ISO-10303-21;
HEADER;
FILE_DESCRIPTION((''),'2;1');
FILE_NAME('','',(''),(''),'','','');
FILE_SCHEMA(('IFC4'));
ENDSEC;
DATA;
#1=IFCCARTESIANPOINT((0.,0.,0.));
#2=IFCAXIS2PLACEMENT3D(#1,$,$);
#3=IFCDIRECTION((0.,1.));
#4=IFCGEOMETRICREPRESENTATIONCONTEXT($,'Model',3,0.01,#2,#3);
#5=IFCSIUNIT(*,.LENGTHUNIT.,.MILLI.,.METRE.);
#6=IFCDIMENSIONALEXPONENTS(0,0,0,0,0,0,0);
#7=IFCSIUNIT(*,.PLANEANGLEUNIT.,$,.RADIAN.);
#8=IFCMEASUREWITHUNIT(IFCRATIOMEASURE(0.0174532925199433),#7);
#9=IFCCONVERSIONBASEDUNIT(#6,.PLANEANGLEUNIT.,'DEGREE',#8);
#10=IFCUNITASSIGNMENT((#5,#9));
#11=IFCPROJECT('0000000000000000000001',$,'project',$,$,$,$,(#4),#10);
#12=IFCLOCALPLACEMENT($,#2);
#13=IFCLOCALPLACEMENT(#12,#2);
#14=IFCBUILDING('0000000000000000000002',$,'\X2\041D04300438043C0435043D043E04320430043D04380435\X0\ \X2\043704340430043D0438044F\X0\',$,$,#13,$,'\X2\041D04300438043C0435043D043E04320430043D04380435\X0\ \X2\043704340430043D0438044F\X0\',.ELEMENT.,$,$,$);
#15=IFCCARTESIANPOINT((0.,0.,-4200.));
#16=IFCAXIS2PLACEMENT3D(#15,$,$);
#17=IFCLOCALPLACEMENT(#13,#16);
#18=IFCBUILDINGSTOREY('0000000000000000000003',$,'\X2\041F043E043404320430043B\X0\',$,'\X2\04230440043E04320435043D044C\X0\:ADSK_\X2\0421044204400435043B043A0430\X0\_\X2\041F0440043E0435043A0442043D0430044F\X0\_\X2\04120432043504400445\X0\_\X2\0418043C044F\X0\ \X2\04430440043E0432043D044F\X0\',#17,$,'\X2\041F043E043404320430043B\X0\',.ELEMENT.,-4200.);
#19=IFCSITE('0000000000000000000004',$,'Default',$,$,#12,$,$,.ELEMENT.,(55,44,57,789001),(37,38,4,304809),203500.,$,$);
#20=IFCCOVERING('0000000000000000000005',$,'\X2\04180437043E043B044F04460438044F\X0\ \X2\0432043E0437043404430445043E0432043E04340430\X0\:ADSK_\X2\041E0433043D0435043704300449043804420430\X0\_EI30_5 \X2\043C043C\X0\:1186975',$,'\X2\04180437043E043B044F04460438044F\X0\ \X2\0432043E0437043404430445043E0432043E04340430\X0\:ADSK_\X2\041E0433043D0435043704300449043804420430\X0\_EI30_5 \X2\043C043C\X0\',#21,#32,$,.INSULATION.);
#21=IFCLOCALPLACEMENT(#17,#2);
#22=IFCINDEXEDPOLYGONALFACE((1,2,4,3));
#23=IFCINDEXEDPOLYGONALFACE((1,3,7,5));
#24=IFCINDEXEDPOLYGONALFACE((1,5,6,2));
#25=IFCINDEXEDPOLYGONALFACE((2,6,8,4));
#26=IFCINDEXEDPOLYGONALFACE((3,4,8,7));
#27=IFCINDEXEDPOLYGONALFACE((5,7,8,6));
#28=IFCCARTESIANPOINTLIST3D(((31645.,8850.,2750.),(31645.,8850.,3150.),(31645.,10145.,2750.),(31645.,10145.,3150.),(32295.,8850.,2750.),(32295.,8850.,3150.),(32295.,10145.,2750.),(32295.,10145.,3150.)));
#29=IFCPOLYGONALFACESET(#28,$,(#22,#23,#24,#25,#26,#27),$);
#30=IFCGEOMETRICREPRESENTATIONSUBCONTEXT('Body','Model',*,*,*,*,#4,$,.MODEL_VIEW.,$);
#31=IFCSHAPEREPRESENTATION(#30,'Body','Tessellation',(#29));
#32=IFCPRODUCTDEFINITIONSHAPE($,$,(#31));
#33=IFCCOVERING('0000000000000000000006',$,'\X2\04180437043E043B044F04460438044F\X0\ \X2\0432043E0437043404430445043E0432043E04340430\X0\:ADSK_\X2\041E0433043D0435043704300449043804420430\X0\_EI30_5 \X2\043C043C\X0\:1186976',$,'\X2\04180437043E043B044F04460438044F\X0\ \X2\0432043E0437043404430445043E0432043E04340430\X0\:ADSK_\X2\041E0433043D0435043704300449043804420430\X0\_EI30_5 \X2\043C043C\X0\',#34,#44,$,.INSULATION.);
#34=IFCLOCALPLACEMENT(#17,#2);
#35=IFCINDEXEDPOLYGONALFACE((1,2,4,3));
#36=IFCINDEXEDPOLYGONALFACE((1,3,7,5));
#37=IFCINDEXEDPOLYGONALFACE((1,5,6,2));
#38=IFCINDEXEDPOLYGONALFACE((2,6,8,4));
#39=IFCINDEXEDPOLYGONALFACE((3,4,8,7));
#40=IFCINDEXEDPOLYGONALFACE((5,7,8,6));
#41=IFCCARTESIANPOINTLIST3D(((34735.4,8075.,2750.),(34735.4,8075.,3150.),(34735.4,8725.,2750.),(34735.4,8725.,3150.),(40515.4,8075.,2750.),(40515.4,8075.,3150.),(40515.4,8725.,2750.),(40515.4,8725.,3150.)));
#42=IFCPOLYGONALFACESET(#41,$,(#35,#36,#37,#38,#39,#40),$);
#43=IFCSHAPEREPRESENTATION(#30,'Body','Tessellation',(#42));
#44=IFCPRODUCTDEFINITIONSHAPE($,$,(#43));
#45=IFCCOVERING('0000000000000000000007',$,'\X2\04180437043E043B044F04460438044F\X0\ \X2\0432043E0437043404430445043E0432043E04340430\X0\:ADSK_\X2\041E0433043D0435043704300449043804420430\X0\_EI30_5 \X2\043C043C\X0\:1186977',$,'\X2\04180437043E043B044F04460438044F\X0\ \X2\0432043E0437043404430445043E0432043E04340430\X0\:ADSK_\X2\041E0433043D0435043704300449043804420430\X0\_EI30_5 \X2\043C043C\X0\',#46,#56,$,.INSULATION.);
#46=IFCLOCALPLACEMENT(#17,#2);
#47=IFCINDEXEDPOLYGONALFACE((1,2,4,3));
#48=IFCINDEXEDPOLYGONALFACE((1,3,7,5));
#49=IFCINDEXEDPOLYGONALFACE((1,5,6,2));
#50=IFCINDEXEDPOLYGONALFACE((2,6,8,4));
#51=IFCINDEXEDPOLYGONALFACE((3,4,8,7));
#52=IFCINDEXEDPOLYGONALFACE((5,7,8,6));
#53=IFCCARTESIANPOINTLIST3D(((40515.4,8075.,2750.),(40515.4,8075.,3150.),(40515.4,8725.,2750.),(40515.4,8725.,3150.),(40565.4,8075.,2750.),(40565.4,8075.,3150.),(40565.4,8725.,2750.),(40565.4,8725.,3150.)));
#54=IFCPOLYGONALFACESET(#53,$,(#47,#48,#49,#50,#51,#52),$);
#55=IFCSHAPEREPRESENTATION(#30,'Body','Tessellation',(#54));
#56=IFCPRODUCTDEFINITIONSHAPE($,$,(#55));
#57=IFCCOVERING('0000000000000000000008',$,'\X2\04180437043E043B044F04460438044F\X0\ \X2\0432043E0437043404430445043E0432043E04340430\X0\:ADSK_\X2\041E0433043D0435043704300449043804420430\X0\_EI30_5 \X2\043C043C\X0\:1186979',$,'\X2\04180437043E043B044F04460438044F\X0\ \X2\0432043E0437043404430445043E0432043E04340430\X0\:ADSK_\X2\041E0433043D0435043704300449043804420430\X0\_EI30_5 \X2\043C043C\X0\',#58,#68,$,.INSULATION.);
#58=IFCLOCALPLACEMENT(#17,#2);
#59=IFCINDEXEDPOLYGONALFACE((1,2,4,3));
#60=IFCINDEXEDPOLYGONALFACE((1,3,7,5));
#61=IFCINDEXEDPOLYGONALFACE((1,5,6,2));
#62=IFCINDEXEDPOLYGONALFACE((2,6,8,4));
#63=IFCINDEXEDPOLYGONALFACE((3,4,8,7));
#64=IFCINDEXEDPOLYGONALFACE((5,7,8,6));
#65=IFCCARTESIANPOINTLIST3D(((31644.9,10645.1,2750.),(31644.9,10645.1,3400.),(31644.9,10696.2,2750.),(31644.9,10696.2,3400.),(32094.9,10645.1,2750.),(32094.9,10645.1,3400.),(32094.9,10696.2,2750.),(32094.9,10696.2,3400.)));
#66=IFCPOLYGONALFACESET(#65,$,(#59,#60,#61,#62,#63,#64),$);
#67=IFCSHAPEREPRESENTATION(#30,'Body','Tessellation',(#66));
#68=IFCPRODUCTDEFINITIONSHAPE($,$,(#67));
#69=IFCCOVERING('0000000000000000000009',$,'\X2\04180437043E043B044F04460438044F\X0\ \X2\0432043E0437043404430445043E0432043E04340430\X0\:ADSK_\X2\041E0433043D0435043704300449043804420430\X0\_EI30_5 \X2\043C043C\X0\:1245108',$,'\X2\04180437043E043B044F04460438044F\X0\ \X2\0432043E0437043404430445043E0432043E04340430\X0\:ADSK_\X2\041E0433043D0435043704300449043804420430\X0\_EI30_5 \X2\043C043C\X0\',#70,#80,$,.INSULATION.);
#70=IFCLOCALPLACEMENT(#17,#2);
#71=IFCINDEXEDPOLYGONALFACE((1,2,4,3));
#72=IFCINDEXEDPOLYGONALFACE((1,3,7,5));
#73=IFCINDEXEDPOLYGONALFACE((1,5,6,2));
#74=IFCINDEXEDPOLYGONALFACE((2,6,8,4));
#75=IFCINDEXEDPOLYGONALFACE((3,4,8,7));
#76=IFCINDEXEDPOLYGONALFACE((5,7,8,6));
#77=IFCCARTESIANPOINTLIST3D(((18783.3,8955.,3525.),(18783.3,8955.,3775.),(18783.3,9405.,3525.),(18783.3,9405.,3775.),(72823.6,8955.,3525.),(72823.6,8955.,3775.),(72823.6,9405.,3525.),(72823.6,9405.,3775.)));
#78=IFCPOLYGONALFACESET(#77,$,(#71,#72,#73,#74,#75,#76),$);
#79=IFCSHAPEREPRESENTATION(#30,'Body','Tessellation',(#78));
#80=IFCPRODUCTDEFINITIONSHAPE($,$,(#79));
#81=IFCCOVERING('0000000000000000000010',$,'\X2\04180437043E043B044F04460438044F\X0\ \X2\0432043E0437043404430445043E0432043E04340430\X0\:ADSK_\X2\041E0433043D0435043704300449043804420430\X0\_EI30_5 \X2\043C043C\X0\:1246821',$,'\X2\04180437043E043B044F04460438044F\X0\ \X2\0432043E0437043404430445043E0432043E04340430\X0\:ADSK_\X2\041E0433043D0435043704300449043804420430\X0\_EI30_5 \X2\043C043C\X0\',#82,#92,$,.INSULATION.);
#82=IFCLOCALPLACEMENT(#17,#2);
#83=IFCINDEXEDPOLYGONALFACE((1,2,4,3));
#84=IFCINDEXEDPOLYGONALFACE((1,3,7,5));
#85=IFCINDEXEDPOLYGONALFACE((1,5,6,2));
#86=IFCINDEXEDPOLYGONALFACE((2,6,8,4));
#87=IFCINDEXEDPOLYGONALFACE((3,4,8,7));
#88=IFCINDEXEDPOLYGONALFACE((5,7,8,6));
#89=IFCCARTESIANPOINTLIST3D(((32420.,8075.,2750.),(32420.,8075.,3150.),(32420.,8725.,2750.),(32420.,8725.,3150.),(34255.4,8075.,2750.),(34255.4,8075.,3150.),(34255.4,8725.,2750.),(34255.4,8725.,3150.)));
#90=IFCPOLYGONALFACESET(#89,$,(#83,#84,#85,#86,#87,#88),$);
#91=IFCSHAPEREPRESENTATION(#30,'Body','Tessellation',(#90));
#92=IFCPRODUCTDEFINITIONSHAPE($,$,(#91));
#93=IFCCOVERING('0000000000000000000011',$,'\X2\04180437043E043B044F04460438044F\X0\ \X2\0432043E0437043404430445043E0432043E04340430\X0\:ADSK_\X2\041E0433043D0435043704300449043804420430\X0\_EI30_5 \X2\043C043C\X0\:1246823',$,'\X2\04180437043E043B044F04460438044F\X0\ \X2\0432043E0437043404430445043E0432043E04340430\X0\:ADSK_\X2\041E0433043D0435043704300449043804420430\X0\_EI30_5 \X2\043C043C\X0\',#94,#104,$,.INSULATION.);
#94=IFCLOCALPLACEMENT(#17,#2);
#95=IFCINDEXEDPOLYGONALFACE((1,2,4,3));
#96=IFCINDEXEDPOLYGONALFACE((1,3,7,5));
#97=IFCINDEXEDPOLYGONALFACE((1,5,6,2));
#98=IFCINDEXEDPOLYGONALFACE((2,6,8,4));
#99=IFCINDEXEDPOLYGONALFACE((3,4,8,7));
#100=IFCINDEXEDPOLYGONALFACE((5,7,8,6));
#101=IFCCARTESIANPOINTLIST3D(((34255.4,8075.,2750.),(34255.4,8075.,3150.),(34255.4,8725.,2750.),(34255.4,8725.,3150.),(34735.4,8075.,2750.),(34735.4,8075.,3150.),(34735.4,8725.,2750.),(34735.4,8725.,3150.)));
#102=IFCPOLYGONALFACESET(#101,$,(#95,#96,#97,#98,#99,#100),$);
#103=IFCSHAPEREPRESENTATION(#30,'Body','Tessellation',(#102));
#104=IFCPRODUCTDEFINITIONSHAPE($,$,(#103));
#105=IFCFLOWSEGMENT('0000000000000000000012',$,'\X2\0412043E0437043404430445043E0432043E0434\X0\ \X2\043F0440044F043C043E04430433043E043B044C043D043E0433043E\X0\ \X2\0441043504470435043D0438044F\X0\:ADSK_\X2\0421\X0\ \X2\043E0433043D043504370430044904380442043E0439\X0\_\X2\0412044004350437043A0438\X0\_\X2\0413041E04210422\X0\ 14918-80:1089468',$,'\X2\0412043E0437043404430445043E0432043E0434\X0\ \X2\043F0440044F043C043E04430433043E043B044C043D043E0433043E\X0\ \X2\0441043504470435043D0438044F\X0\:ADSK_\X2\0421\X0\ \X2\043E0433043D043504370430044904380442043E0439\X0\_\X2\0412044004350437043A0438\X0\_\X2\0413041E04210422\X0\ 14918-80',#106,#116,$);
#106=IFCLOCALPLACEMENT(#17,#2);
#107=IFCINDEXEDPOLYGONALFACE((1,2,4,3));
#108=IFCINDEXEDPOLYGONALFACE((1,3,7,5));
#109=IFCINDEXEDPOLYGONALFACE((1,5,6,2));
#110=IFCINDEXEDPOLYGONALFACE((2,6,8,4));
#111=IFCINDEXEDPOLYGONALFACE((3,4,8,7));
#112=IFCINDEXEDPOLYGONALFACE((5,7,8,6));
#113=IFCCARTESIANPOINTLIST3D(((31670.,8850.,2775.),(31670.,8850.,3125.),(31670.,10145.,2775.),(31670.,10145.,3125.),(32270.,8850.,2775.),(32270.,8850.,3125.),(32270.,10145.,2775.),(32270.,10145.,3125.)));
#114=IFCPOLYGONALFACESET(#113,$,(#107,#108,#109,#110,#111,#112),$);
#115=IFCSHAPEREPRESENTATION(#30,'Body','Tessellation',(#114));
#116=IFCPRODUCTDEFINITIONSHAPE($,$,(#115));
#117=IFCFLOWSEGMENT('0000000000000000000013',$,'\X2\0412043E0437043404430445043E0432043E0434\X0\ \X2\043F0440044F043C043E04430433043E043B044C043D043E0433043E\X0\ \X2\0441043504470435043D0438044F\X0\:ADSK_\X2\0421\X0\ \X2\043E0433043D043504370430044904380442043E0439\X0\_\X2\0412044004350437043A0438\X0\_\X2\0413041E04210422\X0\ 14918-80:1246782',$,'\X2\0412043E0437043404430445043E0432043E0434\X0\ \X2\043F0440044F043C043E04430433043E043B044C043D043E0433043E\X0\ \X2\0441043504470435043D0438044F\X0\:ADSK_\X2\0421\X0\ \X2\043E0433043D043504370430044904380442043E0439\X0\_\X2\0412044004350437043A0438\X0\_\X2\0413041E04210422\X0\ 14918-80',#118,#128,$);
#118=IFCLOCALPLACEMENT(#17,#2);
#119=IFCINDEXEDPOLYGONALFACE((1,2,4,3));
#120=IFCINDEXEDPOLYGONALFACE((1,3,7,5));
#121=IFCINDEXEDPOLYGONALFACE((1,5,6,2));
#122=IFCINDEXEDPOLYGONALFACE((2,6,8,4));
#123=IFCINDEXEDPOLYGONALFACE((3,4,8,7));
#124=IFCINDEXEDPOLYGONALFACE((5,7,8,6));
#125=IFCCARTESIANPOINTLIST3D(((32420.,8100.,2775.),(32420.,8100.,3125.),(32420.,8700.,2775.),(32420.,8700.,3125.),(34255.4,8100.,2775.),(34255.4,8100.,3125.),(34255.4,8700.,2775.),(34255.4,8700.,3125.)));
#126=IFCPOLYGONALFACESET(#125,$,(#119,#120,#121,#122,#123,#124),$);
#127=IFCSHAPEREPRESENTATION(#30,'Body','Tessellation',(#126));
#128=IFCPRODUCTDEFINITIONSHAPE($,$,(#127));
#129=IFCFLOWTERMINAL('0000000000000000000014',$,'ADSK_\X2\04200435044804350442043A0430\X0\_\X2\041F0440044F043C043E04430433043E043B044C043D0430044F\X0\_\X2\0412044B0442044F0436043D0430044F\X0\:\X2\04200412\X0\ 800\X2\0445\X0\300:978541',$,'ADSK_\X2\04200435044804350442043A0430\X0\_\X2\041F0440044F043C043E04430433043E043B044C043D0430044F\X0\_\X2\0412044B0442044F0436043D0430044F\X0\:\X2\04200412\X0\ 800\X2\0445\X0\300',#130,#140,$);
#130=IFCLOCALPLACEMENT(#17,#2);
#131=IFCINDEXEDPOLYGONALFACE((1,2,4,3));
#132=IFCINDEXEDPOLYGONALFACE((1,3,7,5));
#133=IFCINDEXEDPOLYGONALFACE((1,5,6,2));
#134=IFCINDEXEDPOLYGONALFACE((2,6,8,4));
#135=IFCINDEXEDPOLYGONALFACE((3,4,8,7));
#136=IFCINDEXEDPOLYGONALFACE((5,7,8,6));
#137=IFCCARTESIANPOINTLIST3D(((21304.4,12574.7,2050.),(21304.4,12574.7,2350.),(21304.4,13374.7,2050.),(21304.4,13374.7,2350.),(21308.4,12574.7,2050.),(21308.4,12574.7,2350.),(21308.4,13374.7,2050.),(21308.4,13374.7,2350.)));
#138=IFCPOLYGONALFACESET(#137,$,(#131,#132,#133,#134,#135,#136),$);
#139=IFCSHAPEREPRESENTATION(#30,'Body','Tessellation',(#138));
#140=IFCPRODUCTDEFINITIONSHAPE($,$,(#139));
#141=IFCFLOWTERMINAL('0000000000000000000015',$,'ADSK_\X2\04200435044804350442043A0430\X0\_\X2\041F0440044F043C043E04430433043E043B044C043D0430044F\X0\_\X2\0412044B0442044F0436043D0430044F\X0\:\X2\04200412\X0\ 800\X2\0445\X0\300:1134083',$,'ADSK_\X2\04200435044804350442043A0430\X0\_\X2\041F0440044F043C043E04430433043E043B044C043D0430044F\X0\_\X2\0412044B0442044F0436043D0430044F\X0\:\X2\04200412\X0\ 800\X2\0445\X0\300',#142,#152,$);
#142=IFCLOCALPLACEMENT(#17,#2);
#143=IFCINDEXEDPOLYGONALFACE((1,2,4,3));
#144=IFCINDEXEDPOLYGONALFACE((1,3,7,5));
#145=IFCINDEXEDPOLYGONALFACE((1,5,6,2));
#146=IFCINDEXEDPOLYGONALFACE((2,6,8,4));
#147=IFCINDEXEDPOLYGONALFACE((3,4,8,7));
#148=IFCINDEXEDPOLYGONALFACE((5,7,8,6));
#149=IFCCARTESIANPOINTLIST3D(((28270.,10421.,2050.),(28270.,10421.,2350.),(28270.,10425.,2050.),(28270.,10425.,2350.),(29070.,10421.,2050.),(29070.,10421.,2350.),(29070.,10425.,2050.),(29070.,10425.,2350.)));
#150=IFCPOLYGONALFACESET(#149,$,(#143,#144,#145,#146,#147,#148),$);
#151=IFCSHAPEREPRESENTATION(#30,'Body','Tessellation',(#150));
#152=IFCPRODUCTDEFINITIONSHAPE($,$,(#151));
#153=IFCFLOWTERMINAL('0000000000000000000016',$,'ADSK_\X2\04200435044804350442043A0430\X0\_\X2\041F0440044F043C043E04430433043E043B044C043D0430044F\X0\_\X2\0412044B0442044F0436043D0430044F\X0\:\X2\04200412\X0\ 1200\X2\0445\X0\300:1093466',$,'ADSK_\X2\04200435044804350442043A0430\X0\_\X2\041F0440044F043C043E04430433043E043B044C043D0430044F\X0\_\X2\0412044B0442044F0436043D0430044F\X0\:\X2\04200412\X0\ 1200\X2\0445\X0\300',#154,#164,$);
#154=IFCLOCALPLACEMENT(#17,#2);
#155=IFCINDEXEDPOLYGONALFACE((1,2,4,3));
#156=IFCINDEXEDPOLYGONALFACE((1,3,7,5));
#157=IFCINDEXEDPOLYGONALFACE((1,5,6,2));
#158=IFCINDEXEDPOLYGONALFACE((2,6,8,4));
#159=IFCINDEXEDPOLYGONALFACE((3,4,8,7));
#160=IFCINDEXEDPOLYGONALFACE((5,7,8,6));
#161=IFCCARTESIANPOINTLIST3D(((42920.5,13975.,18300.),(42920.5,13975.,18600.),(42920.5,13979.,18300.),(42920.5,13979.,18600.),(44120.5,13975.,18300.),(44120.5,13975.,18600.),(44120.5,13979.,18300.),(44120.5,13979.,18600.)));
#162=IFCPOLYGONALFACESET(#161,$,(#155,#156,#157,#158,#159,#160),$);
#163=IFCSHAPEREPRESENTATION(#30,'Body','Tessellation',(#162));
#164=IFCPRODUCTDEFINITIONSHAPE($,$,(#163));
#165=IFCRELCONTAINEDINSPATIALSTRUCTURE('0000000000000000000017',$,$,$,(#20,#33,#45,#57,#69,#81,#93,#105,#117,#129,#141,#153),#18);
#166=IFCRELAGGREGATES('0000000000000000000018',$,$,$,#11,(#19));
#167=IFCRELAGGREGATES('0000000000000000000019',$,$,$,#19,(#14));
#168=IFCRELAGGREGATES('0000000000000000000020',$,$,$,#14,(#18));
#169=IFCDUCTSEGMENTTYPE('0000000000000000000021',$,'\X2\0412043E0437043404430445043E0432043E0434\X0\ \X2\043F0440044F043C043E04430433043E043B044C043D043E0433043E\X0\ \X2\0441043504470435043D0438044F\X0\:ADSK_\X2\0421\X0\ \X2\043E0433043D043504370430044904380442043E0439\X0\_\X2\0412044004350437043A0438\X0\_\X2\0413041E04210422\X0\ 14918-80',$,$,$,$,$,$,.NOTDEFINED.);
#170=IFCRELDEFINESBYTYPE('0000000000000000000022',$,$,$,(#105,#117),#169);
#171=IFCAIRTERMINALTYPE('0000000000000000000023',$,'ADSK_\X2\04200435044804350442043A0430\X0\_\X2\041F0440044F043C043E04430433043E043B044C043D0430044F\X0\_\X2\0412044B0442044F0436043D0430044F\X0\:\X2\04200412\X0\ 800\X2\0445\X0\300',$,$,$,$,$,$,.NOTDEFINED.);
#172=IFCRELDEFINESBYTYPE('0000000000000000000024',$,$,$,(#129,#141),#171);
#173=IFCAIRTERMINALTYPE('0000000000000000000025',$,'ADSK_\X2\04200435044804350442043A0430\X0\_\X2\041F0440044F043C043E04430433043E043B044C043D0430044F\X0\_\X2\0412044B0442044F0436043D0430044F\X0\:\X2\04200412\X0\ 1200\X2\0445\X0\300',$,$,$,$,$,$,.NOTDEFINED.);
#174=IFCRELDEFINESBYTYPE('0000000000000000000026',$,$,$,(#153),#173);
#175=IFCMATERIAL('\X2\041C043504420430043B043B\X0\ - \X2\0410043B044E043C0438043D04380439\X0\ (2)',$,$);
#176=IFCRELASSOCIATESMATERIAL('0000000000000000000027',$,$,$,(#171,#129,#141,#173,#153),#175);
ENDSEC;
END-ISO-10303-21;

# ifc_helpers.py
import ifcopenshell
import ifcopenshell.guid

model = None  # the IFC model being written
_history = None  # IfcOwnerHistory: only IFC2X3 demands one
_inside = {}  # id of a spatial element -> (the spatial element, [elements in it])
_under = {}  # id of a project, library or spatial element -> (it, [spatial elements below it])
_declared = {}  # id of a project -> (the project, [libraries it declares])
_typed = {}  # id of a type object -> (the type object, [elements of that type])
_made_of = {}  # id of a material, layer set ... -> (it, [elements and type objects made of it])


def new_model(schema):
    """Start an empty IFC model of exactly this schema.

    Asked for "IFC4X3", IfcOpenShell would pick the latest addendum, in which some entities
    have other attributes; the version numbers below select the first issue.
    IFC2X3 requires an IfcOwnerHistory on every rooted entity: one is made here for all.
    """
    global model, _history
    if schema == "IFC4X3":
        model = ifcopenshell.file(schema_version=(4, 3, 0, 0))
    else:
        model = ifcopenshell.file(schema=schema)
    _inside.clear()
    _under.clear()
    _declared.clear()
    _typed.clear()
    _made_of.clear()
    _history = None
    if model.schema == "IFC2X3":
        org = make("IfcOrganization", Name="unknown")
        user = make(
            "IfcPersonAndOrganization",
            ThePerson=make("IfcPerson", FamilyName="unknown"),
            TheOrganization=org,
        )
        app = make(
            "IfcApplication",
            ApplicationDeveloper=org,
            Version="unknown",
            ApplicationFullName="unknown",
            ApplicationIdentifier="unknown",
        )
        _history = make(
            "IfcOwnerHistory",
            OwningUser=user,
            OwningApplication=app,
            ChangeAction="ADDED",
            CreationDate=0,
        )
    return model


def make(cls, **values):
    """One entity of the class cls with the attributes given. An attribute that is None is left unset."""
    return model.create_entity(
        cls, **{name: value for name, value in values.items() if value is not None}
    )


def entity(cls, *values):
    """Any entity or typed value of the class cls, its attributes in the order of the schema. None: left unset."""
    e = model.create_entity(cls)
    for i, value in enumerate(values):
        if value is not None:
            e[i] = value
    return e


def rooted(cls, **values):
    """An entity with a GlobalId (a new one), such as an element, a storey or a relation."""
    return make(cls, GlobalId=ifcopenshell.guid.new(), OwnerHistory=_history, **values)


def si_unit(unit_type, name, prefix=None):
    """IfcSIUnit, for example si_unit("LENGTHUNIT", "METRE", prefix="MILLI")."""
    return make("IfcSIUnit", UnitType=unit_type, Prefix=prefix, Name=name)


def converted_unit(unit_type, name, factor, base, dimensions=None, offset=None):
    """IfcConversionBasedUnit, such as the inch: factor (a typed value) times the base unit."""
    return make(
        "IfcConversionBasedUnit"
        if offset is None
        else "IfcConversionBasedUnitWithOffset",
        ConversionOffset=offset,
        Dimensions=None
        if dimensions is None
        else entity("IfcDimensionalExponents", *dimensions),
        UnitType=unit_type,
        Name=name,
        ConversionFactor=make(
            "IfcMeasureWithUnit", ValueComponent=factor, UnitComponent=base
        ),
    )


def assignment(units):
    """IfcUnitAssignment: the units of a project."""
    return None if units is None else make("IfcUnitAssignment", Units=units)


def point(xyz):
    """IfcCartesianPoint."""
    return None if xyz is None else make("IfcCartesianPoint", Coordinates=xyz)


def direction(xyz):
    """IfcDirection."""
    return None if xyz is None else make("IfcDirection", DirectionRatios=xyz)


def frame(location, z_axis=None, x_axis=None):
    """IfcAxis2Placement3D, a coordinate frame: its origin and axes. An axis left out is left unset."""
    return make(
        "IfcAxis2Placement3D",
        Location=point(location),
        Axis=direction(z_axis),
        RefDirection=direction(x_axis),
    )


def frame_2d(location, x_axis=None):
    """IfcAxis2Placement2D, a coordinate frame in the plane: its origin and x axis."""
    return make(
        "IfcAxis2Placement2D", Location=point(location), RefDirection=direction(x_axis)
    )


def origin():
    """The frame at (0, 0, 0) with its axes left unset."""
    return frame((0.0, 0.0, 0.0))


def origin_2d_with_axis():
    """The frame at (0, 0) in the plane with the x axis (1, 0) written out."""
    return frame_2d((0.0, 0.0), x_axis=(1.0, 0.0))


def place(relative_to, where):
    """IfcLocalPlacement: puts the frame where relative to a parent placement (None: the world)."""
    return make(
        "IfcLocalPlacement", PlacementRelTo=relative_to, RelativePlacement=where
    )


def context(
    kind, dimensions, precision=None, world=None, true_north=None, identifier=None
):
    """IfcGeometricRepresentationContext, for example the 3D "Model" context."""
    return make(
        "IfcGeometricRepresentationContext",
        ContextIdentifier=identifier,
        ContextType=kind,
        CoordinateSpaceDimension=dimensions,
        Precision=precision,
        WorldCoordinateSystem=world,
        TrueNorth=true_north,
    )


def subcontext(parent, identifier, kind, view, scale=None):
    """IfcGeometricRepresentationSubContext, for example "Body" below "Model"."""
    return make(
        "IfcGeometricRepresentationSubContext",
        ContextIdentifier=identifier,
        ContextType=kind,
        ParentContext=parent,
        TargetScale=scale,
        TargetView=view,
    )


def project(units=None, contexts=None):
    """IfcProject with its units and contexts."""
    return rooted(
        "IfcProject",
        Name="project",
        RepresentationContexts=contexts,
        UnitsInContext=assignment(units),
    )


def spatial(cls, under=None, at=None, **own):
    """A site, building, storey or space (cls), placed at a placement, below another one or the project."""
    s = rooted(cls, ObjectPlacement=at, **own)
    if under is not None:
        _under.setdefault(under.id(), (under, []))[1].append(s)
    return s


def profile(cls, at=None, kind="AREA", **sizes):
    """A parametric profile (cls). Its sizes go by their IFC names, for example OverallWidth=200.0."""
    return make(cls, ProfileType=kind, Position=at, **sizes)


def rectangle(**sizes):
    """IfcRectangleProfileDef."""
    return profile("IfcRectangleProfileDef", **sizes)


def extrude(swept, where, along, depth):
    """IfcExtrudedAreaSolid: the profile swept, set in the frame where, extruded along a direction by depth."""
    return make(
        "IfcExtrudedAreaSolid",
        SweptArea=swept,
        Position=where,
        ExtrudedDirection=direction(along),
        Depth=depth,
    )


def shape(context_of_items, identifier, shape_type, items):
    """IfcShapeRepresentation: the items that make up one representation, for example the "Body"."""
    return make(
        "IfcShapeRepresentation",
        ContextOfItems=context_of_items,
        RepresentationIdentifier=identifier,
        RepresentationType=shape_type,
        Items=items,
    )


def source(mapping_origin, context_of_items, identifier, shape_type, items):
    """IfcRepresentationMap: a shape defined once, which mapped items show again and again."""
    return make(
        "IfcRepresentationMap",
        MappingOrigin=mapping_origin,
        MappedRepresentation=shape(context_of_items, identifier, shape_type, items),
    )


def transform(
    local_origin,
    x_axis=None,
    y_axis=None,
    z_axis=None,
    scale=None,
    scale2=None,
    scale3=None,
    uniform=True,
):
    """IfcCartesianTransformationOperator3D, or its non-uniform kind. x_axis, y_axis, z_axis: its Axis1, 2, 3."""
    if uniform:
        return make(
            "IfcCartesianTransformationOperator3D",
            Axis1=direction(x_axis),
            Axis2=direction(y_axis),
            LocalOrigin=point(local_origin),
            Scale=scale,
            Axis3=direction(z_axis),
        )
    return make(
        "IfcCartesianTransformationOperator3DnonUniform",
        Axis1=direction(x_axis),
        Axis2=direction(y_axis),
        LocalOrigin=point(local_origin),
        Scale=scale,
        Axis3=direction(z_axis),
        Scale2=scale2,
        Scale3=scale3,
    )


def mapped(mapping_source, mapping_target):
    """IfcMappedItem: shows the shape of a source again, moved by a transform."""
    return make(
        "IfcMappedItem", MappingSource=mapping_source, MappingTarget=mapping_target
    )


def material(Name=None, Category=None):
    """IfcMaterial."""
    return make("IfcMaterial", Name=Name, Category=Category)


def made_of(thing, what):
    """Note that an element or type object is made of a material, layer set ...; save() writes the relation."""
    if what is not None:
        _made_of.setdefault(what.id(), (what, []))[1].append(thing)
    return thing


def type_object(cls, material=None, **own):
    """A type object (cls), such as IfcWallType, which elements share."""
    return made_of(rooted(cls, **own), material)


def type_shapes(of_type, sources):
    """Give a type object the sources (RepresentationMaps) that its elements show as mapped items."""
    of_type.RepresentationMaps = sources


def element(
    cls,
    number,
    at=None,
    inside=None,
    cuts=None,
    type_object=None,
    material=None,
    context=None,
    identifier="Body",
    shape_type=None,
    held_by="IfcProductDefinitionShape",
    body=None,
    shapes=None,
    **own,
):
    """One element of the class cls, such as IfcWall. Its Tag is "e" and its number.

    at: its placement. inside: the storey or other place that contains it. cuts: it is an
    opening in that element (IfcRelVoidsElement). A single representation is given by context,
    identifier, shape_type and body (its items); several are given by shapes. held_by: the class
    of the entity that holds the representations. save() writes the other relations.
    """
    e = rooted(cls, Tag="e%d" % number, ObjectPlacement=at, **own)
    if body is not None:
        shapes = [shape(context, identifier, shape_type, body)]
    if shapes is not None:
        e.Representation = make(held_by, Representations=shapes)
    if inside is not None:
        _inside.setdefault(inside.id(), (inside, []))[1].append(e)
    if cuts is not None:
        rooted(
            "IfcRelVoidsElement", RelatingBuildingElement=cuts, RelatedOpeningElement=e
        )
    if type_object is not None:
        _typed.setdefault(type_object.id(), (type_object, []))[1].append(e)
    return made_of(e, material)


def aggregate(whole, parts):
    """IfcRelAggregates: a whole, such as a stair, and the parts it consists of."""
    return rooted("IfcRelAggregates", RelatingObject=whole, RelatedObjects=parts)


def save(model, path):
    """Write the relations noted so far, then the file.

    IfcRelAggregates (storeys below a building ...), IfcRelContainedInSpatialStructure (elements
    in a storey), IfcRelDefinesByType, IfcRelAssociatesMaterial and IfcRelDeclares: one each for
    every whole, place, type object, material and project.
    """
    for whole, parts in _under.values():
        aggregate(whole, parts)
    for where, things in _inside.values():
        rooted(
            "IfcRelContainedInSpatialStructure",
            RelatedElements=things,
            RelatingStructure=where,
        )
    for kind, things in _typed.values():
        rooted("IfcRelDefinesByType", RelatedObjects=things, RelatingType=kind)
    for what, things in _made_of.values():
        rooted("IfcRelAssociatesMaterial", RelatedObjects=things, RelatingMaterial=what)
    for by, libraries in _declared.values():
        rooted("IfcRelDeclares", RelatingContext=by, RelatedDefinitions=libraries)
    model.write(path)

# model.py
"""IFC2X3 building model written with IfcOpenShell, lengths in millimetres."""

from ifc_helpers import new_model, entity, si_unit, converted_unit, direction, frame, origin, origin_2d_with_axis, place, context, subcontext, project, spatial, rectangle, extrude, source, transform, mapped, material, type_object, type_shapes, element, save


model = new_model("IFC2X3")

# Units and contexts
model_context = context("Model", 3, precision=0.01, world=origin(), true_north=direction((0.0, 1.0)))
body_context = subcontext(model_context, "Body", "Model", "MODEL_VIEW")
ifc_project = project(units=[si_unit("LENGTHUNIT", "METRE", prefix="MILLI"), converted_unit("PLANEANGLEUNIT", "DEGREE", entity("IfcRatioMeasure", 0.0174532925199433), si_unit("PLANEANGLEUNIT", "RADIAN"), dimensions=[0, 0, 0, 0, 0, 0, 0])], contexts=[model_context])

# Site, building, storey
site_placement = place(None, origin())
site = spatial("IfcSite", under=ifc_project, at=site_placement, Name="Default", CompositionType="ELEMENT", RefLatitude=(55, 44, 57, 789001), RefLongitude=(37, 38, 4, 304809), RefElevation=203500.0)
building_placement = place(site_placement, origin())
building = spatial("IfcBuilding", under=site, at=building_placement, Name="Наименование здания", LongName="Наименование здания", CompositionType="ELEMENT")
storey_placement = place(building_placement, frame((0.0, 0.0, -4200.0)))
storey = spatial("IfcBuildingStorey", under=building, at=storey_placement, Name="Подвал", ObjectType="Уровень:ADSK_Стрелка_Проектная_Вверх_Имя уровня", LongName="Подвал", CompositionType="ELEMENT", Elevation=-4200.0)

# Coverings
covering_1_placement = place(storey_placement, frame((31645.0, 8850.0, 2750.0)))
element("IfcCovering", 1, at=covering_1_placement, inside=storey, Name="Изоляция воздуховода:ADSK_Огнезащита_EI30_5 мм:1186975", ObjectType="Изоляция воздуховода:ADSK_Огнезащита_EI30_5 мм", PredefinedType="INSULATION", context=body_context, shape_type="SweptSolid", body=[
    extrude(rectangle(XDim=1295.0, YDim=650.0, at=origin_2d_with_axis()), frame((325.0, 647.5, 0.0), z_axis=(0.0, 0.0, 1.0), x_axis=(0.0, -1.0, 0.0)), (0.0, 0.0, 1.0), 400.0),
])
covering_2_placement = place(storey_placement, frame((34735.4, 8075.0, 2750.0)))
element("IfcCovering", 2, at=covering_2_placement, inside=storey, Name="Изоляция воздуховода:ADSK_Огнезащита_EI30_5 мм:1186976", ObjectType="Изоляция воздуховода:ADSK_Огнезащита_EI30_5 мм", PredefinedType="INSULATION", context=body_context, shape_type="SweptSolid", body=[
    extrude(rectangle(XDim=5780.0, YDim=650.0, at=origin_2d_with_axis()), frame((2890.0, 325.0, 0.0), z_axis=(0.0, 0.0, 1.0), x_axis=(-1.0, 0.0, 0.0)), (0.0, 0.0, 1.0), 400.0),
])
covering_3_placement = place(storey_placement, frame((40515.4, 8075.0, 2750.0)))
element("IfcCovering", 3, at=covering_3_placement, inside=storey, Name="Изоляция воздуховода:ADSK_Огнезащита_EI30_5 мм:1186977", ObjectType="Изоляция воздуховода:ADSK_Огнезащита_EI30_5 мм", PredefinedType="INSULATION", context=body_context, shape_type="SweptSolid", body=[
    extrude(rectangle(XDim=50.0, YDim=650.0, at=origin_2d_with_axis()), frame((25.0, 325.0, 0.0), z_axis=(0.0, 0.0, 1.0), x_axis=(-1.0, 0.0, 0.0)), (0.0, 0.0, 1.0), 400.0),
])
covering_4_placement = place(storey_placement, frame((31644.9, 10645.1, 2750.0)))
element("IfcCovering", 4, at=covering_4_placement, inside=storey, Name="Изоляция воздуховода:ADSK_Огнезащита_EI30_5 мм:1186979", ObjectType="Изоляция воздуховода:ADSK_Огнезащита_EI30_5 мм", PredefinedType="INSULATION", context=body_context, shape_type="SweptSolid", body=[
    extrude(rectangle(XDim=450.0, YDim=51.1, at=origin_2d_with_axis()), frame((225.0, 25.6, 0.0)), (0.0, 0.0, 1.0), 650.0),
])
covering_5_placement = place(storey_placement, frame((18783.3, 8955.0, 3525.0)))
element("IfcCovering", 5, at=covering_5_placement, inside=storey, Name="Изоляция воздуховода:ADSK_Огнезащита_EI30_5 мм:1245108", ObjectType="Изоляция воздуховода:ADSK_Огнезащита_EI30_5 мм", PredefinedType="INSULATION", context=body_context, shape_type="SweptSolid", body=[
    extrude(rectangle(XDim=54040.3, YDim=450.0, at=origin_2d_with_axis()), frame((27020.2, 225.0, 0.0), z_axis=(0.0, 0.0, 1.0), x_axis=(-1.0, 0.0, 0.0)), (0.0, 0.0, 1.0), 250.0),
])
covering_6_placement = place(storey_placement, frame((32420.0, 8075.0, 2750.0)))
element("IfcCovering", 6, at=covering_6_placement, inside=storey, Name="Изоляция воздуховода:ADSK_Огнезащита_EI30_5 мм:1246821", ObjectType="Изоляция воздуховода:ADSK_Огнезащита_EI30_5 мм", PredefinedType="INSULATION", context=body_context, shape_type="SweptSolid", body=[
    extrude(rectangle(XDim=1835.4, YDim=650.0, at=origin_2d_with_axis()), frame((917.7, 325.0, 0.0)), (0.0, 0.0, 1.0), 400.0),
])
covering_7_placement = place(storey_placement, frame((34255.4, 8075.0, 2750.0)))
element("IfcCovering", 7, at=covering_7_placement, inside=storey, Name="Изоляция воздуховода:ADSK_Огнезащита_EI30_5 мм:1246823", ObjectType="Изоляция воздуховода:ADSK_Огнезащита_EI30_5 мм", PredefinedType="INSULATION", context=body_context, shape_type="SweptSolid", body=[
    extrude(rectangle(XDim=480.0, YDim=650.0, at=origin_2d_with_axis()), frame((240.0, 325.0, 0.0)), (0.0, 0.0, 1.0), 400.0),
])

# Flow segments
duct_segment_type = type_object("IfcDuctSegmentType", Name="Воздуховод прямоугольного сечения:ADSK_С огнезащитой_Врезки_ГОСТ 14918-80", PredefinedType="NOTDEFINED")
flow_segment_1_placement = place(storey_placement, frame((31670.0, 8850.0, 2775.0)))
element("IfcFlowSegment", 8, at=flow_segment_1_placement, inside=storey, type_object=duct_segment_type, Name="Воздуховод прямоугольного сечения:ADSK_С огнезащитой_Врезки_ГОСТ 14918-80:1089468", ObjectType="Воздуховод прямоугольного сечения:ADSK_С огнезащитой_Врезки_ГОСТ 14918-80", context=body_context, shape_type="SweptSolid", body=[
    extrude(rectangle(XDim=1295.0, YDim=600.0, at=origin_2d_with_axis()), frame((300.0, 647.5, 0.0), z_axis=(0.0, 0.0, 1.0), x_axis=(0.0, -1.0, 0.0)), (0.0, 0.0, 1.0), 350.0),
])
flow_segment_2_placement = place(storey_placement, frame((32420.0, 8100.0, 2775.0)))
element("IfcFlowSegment", 9, at=flow_segment_2_placement, inside=storey, type_object=duct_segment_type, Name="Воздуховод прямоугольного сечения:ADSK_С огнезащитой_Врезки_ГОСТ 14918-80:1246782", ObjectType="Воздуховод прямоугольного сечения:ADSK_С огнезащитой_Врезки_ГОСТ 14918-80", context=body_context, shape_type="SweptSolid", body=[
    extrude(rectangle(XDim=1835.4, YDim=600.0, at=origin_2d_with_axis()), frame((917.7, 300.0, 0.0)), (0.0, 0.0, 1.0), 350.0),
])

# Flow terminals
ifc_material_1 = material(Name="Металл - Алюминий (2)")
air_terminal_type_1 = type_object("IfcAirTerminalType", Name="ADSK_Решетка_Прямоугольная_Вытяжная:РВ 800х300", PredefinedType="NOTDEFINED", material=ifc_material_1)
shared_shape_1 = source(origin(), body_context, "Body", "SweptSolid", [
    extrude(rectangle(XDim=4.0, YDim=800.0, at=origin_2d_with_axis()), frame((0.0, -2.0, -150.0), z_axis=(0.0, 0.0, 1.0), x_axis=(0.0, 1.0, 0.0)), (0.0, 0.0, 1.0), 300.0),
])
type_shapes(air_terminal_type_1, [shared_shape_1])
flow_terminal_1_placement = place(storey_placement, frame((21308.4, 12974.7, 2200.0), z_axis=(0.0, 0.0, 1.0), x_axis=(0.0, -1.0, 0.0)))
element("IfcFlowTerminal", 10, at=flow_terminal_1_placement, inside=storey, type_object=air_terminal_type_1, material=ifc_material_1, Name="ADSK_Решетка_Прямоугольная_Вытяжная:РВ 800х300:978541", ObjectType="ADSK_Решетка_Прямоугольная_Вытяжная:РВ 800х300", context=body_context, shape_type="MappedRepresentation", body=[
    mapped(shared_shape_1, transform((0.0, 0.0, 0.0), scale=1.0)),
])
flow_terminal_2_placement = place(storey_placement, frame((28670.0, 10425.0, 2200.0)))
element("IfcFlowTerminal", 11, at=flow_terminal_2_placement, inside=storey, type_object=air_terminal_type_1, material=ifc_material_1, Name="ADSK_Решетка_Прямоугольная_Вытяжная:РВ 800х300:1134083", ObjectType="ADSK_Решетка_Прямоугольная_Вытяжная:РВ 800х300", context=body_context, shape_type="MappedRepresentation", body=[
    mapped(shared_shape_1, transform((0.0, 0.0, 0.0), scale=1.0)),
])
air_terminal_type_2 = type_object("IfcAirTerminalType", Name="ADSK_Решетка_Прямоугольная_Вытяжная:РВ 1200х300", PredefinedType="NOTDEFINED", material=ifc_material_1)
shared_shape_2 = source(origin(), body_context, "Body", "SweptSolid", [
    extrude(rectangle(XDim=4.0, YDim=1200.0, at=origin_2d_with_axis()), frame((0.0, -2.0, -150.0), z_axis=(0.0, 0.0, 1.0), x_axis=(0.0, 1.0, 0.0)), (0.0, 0.0, 1.0), 300.0),
])
type_shapes(air_terminal_type_2, [shared_shape_2])
flow_terminal_3_placement = place(storey_placement, frame((43520.5, 13975.0, 18450.0), z_axis=(0.0, 0.0, -1.0), x_axis=(1.0, 0.0, 0.0)))
element("IfcFlowTerminal", 12, at=flow_terminal_3_placement, inside=storey, type_object=air_terminal_type_2, material=ifc_material_1, Name="ADSK_Решетка_Прямоугольная_Вытяжная:РВ 1200х300:1093466", ObjectType="ADSK_Решетка_Прямоугольная_Вытяжная:РВ 1200х300", context=body_context, shape_type="MappedRepresentation", body=[
    mapped(shared_shape_2, transform((0.0, 0.0, 0.0), scale=1.0)),
])

save(model, "model.ifc")
